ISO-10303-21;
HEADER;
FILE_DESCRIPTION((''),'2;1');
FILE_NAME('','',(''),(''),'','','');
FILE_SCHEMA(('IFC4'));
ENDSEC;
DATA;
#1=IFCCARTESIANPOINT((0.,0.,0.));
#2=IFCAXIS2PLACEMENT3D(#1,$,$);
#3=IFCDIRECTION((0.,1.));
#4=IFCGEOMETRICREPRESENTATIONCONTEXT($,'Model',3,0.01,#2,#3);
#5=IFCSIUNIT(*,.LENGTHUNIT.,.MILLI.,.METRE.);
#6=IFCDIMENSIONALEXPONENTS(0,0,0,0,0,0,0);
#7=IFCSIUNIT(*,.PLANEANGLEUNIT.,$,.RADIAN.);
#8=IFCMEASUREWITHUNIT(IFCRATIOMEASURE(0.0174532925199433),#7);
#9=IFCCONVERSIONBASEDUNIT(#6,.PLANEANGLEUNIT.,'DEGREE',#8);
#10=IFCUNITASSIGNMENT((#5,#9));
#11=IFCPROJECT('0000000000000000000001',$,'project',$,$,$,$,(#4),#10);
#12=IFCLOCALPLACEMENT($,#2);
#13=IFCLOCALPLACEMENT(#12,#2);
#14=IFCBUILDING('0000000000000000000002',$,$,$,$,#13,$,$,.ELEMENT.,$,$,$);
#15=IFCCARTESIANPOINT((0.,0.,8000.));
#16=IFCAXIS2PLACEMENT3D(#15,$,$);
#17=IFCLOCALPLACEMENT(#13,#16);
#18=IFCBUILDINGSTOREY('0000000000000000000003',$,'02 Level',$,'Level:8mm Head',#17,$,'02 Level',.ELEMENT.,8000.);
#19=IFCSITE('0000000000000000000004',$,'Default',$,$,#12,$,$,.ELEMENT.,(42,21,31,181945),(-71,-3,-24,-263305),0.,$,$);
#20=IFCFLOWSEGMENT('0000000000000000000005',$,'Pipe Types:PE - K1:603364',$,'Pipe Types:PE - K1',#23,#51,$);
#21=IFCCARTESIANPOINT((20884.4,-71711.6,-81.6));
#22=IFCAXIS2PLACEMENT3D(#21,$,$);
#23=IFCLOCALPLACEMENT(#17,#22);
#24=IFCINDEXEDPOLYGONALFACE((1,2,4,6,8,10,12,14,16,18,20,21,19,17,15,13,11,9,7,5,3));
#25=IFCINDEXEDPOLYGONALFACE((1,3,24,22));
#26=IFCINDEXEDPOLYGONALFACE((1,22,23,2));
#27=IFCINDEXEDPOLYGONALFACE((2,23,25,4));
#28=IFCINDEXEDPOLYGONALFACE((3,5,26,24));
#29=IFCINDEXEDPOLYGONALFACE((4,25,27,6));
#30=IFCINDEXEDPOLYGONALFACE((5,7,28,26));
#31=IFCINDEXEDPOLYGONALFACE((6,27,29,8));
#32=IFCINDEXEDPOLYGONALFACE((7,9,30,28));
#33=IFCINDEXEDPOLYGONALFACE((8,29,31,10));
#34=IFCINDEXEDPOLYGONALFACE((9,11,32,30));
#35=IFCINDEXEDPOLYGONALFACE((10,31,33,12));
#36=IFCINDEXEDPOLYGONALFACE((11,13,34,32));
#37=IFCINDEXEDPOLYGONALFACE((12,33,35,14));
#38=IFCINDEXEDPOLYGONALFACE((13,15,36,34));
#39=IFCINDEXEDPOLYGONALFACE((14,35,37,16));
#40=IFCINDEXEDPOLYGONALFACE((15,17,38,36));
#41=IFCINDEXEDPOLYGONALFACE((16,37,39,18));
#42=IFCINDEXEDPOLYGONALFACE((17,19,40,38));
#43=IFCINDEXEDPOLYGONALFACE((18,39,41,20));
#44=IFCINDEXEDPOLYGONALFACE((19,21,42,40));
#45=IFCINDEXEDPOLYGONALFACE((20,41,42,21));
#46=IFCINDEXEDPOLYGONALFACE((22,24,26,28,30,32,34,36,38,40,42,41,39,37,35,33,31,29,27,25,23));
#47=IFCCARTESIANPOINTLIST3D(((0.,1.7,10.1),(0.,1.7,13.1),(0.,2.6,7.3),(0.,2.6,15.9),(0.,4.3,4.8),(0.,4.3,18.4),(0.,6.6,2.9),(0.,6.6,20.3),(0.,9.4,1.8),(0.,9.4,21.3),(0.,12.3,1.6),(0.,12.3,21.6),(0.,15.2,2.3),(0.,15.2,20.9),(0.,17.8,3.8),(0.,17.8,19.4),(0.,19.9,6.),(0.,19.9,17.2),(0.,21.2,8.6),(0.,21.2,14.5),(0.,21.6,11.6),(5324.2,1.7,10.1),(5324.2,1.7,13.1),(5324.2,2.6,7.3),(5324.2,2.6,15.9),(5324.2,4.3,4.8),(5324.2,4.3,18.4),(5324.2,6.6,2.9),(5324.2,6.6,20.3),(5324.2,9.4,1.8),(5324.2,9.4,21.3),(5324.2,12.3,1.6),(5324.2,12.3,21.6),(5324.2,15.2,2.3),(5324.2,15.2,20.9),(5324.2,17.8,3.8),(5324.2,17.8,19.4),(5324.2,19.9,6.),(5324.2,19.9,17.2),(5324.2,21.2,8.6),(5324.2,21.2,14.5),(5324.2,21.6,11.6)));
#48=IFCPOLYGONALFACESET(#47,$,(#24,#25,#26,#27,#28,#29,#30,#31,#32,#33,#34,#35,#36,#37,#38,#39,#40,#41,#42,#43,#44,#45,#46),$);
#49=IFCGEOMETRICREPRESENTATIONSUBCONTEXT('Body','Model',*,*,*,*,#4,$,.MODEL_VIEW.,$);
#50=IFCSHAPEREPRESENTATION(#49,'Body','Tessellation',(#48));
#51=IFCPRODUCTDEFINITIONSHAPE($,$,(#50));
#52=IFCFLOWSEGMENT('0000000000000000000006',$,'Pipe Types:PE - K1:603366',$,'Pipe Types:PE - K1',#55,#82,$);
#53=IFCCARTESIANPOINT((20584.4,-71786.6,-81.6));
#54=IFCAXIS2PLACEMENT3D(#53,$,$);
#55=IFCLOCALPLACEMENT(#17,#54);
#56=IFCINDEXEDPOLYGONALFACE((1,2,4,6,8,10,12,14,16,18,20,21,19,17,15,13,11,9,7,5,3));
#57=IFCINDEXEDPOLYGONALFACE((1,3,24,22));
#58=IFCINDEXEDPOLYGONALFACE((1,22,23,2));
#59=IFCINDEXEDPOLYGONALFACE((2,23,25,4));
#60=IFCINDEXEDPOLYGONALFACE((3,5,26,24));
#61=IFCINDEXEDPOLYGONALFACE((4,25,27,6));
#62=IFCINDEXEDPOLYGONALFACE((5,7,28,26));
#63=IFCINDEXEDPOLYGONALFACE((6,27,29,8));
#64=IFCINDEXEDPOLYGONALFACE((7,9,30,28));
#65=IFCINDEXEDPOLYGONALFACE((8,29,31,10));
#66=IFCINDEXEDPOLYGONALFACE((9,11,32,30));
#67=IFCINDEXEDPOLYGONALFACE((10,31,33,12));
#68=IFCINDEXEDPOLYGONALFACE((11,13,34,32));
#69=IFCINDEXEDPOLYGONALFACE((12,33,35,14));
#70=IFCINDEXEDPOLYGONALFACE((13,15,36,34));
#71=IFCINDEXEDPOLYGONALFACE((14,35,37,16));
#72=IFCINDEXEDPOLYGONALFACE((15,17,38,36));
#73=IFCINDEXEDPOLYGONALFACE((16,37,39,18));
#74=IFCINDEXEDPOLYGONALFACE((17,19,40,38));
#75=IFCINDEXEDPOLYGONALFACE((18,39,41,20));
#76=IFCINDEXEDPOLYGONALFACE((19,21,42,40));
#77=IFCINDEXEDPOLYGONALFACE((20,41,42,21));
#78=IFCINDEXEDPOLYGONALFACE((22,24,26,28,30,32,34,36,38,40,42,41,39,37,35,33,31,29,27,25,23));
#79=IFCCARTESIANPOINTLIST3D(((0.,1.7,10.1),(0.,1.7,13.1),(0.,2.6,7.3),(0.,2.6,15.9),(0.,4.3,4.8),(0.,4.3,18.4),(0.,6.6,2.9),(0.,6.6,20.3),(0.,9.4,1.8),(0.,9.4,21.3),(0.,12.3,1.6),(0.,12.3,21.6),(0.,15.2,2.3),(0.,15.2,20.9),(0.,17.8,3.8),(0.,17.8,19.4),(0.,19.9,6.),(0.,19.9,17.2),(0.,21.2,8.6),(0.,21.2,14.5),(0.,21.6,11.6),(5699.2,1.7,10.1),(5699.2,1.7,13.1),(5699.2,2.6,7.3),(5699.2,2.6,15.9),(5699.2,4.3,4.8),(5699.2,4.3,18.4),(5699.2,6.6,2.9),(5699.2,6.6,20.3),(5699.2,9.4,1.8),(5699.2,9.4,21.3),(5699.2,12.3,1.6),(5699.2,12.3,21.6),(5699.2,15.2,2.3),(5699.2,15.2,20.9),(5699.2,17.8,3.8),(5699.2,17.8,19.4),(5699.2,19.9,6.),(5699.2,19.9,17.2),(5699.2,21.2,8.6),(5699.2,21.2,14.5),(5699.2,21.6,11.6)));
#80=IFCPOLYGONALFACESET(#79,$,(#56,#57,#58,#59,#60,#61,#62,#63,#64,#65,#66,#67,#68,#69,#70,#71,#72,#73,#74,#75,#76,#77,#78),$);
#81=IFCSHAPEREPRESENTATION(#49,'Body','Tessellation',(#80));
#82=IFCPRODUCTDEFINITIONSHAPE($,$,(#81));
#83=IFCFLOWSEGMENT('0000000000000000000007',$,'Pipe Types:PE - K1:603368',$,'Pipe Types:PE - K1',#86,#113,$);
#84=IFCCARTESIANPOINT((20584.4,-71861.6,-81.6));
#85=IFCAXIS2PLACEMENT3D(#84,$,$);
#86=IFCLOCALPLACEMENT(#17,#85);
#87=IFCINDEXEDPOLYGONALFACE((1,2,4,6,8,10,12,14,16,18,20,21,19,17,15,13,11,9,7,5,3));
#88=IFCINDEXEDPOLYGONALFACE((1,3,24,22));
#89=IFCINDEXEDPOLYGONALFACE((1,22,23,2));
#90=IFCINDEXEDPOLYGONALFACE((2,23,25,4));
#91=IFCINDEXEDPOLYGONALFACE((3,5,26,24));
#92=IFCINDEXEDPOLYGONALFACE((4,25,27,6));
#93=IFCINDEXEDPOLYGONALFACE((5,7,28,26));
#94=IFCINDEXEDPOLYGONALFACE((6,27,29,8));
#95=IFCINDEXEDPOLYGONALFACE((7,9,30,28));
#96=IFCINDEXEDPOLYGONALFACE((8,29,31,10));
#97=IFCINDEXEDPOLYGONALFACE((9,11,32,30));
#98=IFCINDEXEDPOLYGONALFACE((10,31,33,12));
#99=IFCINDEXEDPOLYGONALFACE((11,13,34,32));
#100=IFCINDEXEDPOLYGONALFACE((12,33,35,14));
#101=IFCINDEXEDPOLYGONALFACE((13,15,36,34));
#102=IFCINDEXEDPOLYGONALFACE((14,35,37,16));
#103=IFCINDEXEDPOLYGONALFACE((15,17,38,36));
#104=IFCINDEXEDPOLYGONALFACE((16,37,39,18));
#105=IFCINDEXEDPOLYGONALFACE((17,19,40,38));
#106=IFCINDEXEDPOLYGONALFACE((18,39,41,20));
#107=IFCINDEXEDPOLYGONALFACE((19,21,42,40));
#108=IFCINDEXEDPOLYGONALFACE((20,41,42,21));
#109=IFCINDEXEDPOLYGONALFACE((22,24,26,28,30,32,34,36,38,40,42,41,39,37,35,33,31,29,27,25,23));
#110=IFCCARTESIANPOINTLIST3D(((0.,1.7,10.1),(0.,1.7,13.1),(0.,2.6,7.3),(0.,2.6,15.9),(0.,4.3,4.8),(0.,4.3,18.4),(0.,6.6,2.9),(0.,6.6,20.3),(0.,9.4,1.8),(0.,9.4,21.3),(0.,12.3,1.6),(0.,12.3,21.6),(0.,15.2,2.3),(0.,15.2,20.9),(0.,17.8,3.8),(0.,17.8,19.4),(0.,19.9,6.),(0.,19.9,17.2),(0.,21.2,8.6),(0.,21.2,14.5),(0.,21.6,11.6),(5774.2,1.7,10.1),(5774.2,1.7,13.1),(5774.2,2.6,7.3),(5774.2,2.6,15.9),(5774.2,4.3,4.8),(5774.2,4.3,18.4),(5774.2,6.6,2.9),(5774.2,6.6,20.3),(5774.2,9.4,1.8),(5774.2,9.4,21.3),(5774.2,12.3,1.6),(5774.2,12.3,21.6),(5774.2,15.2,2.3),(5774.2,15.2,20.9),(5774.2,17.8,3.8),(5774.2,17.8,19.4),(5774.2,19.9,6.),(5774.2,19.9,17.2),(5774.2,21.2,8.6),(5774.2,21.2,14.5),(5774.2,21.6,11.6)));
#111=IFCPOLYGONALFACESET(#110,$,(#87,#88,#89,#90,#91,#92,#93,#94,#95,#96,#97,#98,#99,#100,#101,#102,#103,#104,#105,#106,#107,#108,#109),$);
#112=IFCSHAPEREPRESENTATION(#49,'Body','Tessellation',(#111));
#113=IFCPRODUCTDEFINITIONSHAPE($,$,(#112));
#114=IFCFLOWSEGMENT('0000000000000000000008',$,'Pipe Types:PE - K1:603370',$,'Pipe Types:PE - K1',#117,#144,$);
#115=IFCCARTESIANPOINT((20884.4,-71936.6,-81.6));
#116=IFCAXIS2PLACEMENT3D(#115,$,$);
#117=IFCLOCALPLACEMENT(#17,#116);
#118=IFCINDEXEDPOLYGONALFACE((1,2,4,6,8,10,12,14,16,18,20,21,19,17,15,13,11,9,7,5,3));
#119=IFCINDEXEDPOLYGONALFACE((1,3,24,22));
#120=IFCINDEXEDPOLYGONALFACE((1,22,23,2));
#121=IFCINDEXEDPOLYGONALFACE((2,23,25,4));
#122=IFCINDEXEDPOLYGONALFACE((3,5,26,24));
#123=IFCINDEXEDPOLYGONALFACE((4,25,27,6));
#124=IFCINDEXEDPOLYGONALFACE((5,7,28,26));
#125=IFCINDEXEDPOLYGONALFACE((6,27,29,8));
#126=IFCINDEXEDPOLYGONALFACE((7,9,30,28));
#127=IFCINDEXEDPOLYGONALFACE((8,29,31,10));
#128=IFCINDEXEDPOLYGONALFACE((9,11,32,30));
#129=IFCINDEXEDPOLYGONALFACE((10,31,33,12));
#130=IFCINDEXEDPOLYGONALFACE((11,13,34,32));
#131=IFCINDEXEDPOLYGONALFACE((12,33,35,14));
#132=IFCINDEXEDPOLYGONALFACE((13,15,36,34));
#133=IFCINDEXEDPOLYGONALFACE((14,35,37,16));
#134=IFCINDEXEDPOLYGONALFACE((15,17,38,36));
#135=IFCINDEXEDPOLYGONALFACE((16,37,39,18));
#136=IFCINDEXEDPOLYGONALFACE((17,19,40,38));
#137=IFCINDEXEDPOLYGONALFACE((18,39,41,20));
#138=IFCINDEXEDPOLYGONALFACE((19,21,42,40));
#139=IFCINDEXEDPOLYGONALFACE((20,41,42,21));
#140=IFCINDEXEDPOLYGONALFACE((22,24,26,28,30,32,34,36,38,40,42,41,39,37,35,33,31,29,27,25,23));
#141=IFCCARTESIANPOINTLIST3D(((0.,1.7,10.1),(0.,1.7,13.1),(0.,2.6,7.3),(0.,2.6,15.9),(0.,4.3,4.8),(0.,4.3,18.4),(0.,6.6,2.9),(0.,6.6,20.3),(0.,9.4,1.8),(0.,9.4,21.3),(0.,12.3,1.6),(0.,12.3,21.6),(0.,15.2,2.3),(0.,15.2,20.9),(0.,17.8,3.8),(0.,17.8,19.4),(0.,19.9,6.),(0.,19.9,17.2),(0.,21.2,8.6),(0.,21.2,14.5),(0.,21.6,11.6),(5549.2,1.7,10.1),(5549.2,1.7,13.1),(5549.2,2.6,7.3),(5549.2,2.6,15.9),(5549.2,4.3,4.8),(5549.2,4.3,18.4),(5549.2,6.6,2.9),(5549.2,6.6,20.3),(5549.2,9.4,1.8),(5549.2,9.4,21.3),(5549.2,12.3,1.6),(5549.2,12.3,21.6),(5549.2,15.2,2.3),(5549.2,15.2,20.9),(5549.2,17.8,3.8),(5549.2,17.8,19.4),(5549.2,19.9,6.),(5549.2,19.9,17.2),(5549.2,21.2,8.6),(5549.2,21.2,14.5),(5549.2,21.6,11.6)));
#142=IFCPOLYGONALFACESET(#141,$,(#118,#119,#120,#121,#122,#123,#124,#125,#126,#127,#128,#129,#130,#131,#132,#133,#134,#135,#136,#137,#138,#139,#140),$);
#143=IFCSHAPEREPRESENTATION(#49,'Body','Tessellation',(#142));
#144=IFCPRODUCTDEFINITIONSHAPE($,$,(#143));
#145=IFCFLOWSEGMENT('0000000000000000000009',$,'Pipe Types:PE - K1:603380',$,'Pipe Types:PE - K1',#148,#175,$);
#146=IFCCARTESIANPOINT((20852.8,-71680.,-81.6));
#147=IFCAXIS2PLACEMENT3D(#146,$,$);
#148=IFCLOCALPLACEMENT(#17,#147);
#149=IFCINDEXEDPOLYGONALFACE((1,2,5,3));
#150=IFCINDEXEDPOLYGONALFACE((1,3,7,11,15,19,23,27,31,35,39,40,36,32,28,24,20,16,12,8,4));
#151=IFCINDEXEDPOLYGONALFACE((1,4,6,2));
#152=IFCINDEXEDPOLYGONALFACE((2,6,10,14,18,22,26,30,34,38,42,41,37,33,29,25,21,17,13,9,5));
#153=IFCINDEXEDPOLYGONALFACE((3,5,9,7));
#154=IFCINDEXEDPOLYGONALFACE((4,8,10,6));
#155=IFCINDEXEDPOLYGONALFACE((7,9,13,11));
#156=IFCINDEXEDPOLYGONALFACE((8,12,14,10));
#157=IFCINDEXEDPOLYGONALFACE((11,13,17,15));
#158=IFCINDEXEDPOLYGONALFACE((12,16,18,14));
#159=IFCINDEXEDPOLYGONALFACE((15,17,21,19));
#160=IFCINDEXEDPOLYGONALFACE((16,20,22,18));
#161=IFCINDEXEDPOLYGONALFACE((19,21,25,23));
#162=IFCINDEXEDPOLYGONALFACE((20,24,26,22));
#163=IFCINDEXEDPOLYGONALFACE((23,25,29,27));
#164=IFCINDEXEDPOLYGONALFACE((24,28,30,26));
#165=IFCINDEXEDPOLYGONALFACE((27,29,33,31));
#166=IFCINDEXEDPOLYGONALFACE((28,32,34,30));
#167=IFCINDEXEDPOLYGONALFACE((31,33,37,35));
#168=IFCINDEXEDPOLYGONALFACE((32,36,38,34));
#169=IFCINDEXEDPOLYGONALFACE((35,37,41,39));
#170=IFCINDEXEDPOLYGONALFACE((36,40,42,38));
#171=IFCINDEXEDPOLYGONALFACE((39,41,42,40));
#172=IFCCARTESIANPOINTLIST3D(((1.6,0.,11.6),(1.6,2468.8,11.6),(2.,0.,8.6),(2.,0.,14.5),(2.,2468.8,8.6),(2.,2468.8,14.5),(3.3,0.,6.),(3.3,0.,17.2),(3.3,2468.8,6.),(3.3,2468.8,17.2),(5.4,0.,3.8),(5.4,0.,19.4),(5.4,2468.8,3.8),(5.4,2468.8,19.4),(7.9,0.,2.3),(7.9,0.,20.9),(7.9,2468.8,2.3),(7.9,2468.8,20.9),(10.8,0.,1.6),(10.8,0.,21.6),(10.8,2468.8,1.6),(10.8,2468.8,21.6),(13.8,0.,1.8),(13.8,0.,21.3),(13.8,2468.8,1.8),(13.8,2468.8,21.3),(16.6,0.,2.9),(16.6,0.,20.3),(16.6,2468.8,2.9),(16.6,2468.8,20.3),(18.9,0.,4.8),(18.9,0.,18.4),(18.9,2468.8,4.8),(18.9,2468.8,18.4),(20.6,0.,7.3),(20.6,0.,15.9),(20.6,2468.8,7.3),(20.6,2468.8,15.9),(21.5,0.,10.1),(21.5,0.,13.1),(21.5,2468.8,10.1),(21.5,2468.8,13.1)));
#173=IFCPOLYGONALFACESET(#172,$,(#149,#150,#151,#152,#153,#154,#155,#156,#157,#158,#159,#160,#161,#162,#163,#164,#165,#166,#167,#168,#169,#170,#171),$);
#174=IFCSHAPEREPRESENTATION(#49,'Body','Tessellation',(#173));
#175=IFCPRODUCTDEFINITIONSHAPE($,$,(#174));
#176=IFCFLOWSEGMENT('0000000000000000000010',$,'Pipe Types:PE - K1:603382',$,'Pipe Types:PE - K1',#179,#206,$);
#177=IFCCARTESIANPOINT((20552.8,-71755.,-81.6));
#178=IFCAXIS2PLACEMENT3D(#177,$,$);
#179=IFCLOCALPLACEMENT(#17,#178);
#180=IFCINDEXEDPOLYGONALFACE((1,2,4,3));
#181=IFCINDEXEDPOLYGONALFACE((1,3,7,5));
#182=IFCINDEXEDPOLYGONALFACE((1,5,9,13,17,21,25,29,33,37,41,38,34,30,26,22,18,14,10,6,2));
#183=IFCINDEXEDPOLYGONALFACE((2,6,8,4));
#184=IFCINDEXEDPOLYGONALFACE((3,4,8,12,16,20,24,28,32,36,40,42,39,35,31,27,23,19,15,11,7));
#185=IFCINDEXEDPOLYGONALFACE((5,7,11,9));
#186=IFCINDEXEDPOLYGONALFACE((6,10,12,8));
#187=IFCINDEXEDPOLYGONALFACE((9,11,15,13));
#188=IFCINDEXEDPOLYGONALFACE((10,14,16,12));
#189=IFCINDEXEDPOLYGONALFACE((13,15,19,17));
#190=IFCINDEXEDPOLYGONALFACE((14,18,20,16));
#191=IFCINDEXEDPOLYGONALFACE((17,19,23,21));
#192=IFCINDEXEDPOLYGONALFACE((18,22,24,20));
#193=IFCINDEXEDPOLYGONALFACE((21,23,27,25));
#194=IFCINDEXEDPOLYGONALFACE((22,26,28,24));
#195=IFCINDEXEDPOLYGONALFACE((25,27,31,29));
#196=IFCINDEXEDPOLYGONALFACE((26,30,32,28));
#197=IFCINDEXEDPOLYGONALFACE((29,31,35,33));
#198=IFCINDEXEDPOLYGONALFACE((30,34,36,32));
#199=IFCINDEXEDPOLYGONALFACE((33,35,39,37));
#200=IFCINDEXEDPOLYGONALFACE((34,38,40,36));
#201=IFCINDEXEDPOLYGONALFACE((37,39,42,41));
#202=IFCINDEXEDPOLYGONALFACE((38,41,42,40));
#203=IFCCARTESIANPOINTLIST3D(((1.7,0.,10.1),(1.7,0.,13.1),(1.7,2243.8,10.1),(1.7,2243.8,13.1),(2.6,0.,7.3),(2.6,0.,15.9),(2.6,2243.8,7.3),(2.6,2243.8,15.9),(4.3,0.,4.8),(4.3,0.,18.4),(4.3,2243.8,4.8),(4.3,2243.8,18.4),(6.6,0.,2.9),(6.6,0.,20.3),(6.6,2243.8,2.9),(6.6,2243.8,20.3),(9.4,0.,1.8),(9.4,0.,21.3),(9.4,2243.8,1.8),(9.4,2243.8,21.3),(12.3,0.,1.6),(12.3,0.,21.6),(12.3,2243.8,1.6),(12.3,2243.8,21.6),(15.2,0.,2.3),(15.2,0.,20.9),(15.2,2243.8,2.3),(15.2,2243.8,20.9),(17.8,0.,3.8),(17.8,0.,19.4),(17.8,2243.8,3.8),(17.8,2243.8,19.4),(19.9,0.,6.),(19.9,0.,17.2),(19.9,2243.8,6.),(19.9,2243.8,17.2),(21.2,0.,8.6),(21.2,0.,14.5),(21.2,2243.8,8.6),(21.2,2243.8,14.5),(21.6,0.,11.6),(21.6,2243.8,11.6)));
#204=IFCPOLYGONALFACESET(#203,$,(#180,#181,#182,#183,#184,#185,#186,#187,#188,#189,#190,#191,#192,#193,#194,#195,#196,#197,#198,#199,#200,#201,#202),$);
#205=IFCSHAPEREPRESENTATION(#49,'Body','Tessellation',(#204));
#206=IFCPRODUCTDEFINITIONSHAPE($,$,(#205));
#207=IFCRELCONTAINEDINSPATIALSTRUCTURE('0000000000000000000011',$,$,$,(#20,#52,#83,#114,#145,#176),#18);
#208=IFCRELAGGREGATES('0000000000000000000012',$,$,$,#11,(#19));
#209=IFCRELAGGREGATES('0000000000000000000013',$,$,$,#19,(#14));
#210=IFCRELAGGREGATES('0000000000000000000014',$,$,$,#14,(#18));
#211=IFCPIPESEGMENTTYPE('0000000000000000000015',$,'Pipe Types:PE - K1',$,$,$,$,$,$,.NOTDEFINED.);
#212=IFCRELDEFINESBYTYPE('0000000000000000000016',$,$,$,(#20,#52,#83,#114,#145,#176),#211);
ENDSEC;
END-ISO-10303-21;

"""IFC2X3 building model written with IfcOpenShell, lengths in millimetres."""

from ifc_helpers import new_model, entity, si_unit, converted_unit, direction, frame, frame_2d, origin, origin_2d_with_axis, place, context, subcontext, project, spatial, circle, extrude, type_object, element, save


model = new_model("IFC2X3")

# Units and contexts
model_context = context("Model", 3, precision=0.01, world=origin(), true_north=direction((0.0, 1.0)))
body_context = subcontext(model_context, "Body", "Model", "MODEL_VIEW")
ifc_project = project(units=[si_unit("LENGTHUNIT", "METRE", prefix="MILLI"), converted_unit("PLANEANGLEUNIT", "DEGREE", entity("IfcRatioMeasure", 0.0174532925199433), si_unit("PLANEANGLEUNIT", "RADIAN"), dimensions=[0, 0, 0, 0, 0, 0, 0])], contexts=[model_context])

# Site, building, storey
site_placement = place(None, origin())
site = spatial("IfcSite", under=ifc_project, at=site_placement, Name="Default", CompositionType="ELEMENT", RefLatitude=(42, 21, 31, 181945), RefLongitude=(-71, -3, -24, -263305), RefElevation=0.0)
building_placement = place(site_placement, origin())
building = spatial("IfcBuilding", under=site, at=building_placement, CompositionType="ELEMENT")
storey_placement = place(building_placement, frame((0.0, 0.0, 8000.0)))
storey = spatial("IfcBuildingStorey", under=building, at=storey_placement, Name="02 Level", ObjectType="Level:8mm Head", LongName="02 Level", CompositionType="ELEMENT", Elevation=8000.0)

# Flow segments
pipe_segment_type = type_object("IfcPipeSegmentType", Name="Pipe Types:PE - K1", PredefinedType="NOTDEFINED")
flow_segment_1_placement = place(storey_placement, frame((20884.4, -71711.6, -81.6)))
element("IfcFlowSegment", 1, at=flow_segment_1_placement, inside=storey, type_object=pipe_segment_type, Name="Pipe Types:PE - K1:603364", ObjectType="Pipe Types:PE - K1", context=body_context, shape_type="SweptSolid", body=[
    extrude(circle(Radius=10.0, at=frame_2d((0.0, 0.0), x_axis=(1.0, 0.0))), frame((0.0, 11.6, 11.6), z_axis=(1.0, 0.0, 0.0), x_axis=(0.0, 1.0, 0.0)), (0.0, 0.0, 1.0), 5324.2),
])
flow_segment_2_placement = place(storey_placement, frame((20584.4, -71786.6, -81.6)))
element("IfcFlowSegment", 2, at=flow_segment_2_placement, inside=storey, type_object=pipe_segment_type, Name="Pipe Types:PE - K1:603366", ObjectType="Pipe Types:PE - K1", context=body_context, shape_type="SweptSolid", body=[
    extrude(circle(Radius=10.0, at=frame_2d((0.0, 0.0), x_axis=(1.0, 0.0))), frame((0.0, 11.6, 11.6), z_axis=(1.0, 0.0, 0.0), x_axis=(0.0, 1.0, 0.0)), (0.0, 0.0, 1.0), 5699.2),
])
flow_segment_3_placement = place(storey_placement, frame((20584.4, -71861.6, -81.6)))
element("IfcFlowSegment", 3, at=flow_segment_3_placement, inside=storey, type_object=pipe_segment_type, Name="Pipe Types:PE - K1:603368", ObjectType="Pipe Types:PE - K1", context=body_context, shape_type="SweptSolid", body=[
    extrude(circle(Radius=10.0, at=frame_2d((0.0, 0.0), x_axis=(1.0, 0.0))), frame((0.0, 11.6, 11.6), z_axis=(1.0, 0.0, 0.0), x_axis=(0.0, 1.0, 0.0)), (0.0, 0.0, 1.0), 5774.2),
])
flow_segment_4_placement = place(storey_placement, frame((20884.4, -71936.6, -81.6)))
element("IfcFlowSegment", 4, at=flow_segment_4_placement, inside=storey, type_object=pipe_segment_type, Name="Pipe Types:PE - K1:603370", ObjectType="Pipe Types:PE - K1", context=body_context, shape_type="SweptSolid", body=[
    extrude(circle(Radius=10.0, at=frame_2d((0.0, 0.0), x_axis=(1.0, 0.0))), frame((0.0, 11.6, 11.6), z_axis=(1.0, 0.0, 0.0), x_axis=(0.0, 1.0, 0.0)), (0.0, 0.0, 1.0), 5549.2),
])
flow_segment_5_placement = place(storey_placement, frame((20852.8, -71680.0, -81.6)))
element("IfcFlowSegment", 5, at=flow_segment_5_placement, inside=storey, type_object=pipe_segment_type, Name="Pipe Types:PE - K1:603380", ObjectType="Pipe Types:PE - K1", context=body_context, shape_type="SweptSolid", body=[
    extrude(circle(Radius=10.0, at=frame_2d((0.0, 0.0), x_axis=(1.0, 0.0))), frame((11.6, 0.0, 11.6), z_axis=(0.0, 1.0, 0.0), x_axis=(-1.0, 0.0, 0.0)), (0.0, 0.0, 1.0), 2468.8),
])
flow_segment_6_placement = place(storey_placement, frame((20552.8, -71755.0, -81.6)))
element("IfcFlowSegment", 6, at=flow_segment_6_placement, inside=storey, type_object=pipe_segment_type, Name="Pipe Types:PE - K1:603382", ObjectType="Pipe Types:PE - K1", context=body_context, shape_type="SweptSolid", body=[
    extrude(circle(Radius=10.0, at=origin_2d_with_axis()), frame((11.6, 0.0, 11.6), z_axis=(0.0, 1.0, 0.0), x_axis=(1.0, 0.0, 0.0)), (0.0, 0.0, 1.0), 2243.8),
])

save(model, "model.ifc")
